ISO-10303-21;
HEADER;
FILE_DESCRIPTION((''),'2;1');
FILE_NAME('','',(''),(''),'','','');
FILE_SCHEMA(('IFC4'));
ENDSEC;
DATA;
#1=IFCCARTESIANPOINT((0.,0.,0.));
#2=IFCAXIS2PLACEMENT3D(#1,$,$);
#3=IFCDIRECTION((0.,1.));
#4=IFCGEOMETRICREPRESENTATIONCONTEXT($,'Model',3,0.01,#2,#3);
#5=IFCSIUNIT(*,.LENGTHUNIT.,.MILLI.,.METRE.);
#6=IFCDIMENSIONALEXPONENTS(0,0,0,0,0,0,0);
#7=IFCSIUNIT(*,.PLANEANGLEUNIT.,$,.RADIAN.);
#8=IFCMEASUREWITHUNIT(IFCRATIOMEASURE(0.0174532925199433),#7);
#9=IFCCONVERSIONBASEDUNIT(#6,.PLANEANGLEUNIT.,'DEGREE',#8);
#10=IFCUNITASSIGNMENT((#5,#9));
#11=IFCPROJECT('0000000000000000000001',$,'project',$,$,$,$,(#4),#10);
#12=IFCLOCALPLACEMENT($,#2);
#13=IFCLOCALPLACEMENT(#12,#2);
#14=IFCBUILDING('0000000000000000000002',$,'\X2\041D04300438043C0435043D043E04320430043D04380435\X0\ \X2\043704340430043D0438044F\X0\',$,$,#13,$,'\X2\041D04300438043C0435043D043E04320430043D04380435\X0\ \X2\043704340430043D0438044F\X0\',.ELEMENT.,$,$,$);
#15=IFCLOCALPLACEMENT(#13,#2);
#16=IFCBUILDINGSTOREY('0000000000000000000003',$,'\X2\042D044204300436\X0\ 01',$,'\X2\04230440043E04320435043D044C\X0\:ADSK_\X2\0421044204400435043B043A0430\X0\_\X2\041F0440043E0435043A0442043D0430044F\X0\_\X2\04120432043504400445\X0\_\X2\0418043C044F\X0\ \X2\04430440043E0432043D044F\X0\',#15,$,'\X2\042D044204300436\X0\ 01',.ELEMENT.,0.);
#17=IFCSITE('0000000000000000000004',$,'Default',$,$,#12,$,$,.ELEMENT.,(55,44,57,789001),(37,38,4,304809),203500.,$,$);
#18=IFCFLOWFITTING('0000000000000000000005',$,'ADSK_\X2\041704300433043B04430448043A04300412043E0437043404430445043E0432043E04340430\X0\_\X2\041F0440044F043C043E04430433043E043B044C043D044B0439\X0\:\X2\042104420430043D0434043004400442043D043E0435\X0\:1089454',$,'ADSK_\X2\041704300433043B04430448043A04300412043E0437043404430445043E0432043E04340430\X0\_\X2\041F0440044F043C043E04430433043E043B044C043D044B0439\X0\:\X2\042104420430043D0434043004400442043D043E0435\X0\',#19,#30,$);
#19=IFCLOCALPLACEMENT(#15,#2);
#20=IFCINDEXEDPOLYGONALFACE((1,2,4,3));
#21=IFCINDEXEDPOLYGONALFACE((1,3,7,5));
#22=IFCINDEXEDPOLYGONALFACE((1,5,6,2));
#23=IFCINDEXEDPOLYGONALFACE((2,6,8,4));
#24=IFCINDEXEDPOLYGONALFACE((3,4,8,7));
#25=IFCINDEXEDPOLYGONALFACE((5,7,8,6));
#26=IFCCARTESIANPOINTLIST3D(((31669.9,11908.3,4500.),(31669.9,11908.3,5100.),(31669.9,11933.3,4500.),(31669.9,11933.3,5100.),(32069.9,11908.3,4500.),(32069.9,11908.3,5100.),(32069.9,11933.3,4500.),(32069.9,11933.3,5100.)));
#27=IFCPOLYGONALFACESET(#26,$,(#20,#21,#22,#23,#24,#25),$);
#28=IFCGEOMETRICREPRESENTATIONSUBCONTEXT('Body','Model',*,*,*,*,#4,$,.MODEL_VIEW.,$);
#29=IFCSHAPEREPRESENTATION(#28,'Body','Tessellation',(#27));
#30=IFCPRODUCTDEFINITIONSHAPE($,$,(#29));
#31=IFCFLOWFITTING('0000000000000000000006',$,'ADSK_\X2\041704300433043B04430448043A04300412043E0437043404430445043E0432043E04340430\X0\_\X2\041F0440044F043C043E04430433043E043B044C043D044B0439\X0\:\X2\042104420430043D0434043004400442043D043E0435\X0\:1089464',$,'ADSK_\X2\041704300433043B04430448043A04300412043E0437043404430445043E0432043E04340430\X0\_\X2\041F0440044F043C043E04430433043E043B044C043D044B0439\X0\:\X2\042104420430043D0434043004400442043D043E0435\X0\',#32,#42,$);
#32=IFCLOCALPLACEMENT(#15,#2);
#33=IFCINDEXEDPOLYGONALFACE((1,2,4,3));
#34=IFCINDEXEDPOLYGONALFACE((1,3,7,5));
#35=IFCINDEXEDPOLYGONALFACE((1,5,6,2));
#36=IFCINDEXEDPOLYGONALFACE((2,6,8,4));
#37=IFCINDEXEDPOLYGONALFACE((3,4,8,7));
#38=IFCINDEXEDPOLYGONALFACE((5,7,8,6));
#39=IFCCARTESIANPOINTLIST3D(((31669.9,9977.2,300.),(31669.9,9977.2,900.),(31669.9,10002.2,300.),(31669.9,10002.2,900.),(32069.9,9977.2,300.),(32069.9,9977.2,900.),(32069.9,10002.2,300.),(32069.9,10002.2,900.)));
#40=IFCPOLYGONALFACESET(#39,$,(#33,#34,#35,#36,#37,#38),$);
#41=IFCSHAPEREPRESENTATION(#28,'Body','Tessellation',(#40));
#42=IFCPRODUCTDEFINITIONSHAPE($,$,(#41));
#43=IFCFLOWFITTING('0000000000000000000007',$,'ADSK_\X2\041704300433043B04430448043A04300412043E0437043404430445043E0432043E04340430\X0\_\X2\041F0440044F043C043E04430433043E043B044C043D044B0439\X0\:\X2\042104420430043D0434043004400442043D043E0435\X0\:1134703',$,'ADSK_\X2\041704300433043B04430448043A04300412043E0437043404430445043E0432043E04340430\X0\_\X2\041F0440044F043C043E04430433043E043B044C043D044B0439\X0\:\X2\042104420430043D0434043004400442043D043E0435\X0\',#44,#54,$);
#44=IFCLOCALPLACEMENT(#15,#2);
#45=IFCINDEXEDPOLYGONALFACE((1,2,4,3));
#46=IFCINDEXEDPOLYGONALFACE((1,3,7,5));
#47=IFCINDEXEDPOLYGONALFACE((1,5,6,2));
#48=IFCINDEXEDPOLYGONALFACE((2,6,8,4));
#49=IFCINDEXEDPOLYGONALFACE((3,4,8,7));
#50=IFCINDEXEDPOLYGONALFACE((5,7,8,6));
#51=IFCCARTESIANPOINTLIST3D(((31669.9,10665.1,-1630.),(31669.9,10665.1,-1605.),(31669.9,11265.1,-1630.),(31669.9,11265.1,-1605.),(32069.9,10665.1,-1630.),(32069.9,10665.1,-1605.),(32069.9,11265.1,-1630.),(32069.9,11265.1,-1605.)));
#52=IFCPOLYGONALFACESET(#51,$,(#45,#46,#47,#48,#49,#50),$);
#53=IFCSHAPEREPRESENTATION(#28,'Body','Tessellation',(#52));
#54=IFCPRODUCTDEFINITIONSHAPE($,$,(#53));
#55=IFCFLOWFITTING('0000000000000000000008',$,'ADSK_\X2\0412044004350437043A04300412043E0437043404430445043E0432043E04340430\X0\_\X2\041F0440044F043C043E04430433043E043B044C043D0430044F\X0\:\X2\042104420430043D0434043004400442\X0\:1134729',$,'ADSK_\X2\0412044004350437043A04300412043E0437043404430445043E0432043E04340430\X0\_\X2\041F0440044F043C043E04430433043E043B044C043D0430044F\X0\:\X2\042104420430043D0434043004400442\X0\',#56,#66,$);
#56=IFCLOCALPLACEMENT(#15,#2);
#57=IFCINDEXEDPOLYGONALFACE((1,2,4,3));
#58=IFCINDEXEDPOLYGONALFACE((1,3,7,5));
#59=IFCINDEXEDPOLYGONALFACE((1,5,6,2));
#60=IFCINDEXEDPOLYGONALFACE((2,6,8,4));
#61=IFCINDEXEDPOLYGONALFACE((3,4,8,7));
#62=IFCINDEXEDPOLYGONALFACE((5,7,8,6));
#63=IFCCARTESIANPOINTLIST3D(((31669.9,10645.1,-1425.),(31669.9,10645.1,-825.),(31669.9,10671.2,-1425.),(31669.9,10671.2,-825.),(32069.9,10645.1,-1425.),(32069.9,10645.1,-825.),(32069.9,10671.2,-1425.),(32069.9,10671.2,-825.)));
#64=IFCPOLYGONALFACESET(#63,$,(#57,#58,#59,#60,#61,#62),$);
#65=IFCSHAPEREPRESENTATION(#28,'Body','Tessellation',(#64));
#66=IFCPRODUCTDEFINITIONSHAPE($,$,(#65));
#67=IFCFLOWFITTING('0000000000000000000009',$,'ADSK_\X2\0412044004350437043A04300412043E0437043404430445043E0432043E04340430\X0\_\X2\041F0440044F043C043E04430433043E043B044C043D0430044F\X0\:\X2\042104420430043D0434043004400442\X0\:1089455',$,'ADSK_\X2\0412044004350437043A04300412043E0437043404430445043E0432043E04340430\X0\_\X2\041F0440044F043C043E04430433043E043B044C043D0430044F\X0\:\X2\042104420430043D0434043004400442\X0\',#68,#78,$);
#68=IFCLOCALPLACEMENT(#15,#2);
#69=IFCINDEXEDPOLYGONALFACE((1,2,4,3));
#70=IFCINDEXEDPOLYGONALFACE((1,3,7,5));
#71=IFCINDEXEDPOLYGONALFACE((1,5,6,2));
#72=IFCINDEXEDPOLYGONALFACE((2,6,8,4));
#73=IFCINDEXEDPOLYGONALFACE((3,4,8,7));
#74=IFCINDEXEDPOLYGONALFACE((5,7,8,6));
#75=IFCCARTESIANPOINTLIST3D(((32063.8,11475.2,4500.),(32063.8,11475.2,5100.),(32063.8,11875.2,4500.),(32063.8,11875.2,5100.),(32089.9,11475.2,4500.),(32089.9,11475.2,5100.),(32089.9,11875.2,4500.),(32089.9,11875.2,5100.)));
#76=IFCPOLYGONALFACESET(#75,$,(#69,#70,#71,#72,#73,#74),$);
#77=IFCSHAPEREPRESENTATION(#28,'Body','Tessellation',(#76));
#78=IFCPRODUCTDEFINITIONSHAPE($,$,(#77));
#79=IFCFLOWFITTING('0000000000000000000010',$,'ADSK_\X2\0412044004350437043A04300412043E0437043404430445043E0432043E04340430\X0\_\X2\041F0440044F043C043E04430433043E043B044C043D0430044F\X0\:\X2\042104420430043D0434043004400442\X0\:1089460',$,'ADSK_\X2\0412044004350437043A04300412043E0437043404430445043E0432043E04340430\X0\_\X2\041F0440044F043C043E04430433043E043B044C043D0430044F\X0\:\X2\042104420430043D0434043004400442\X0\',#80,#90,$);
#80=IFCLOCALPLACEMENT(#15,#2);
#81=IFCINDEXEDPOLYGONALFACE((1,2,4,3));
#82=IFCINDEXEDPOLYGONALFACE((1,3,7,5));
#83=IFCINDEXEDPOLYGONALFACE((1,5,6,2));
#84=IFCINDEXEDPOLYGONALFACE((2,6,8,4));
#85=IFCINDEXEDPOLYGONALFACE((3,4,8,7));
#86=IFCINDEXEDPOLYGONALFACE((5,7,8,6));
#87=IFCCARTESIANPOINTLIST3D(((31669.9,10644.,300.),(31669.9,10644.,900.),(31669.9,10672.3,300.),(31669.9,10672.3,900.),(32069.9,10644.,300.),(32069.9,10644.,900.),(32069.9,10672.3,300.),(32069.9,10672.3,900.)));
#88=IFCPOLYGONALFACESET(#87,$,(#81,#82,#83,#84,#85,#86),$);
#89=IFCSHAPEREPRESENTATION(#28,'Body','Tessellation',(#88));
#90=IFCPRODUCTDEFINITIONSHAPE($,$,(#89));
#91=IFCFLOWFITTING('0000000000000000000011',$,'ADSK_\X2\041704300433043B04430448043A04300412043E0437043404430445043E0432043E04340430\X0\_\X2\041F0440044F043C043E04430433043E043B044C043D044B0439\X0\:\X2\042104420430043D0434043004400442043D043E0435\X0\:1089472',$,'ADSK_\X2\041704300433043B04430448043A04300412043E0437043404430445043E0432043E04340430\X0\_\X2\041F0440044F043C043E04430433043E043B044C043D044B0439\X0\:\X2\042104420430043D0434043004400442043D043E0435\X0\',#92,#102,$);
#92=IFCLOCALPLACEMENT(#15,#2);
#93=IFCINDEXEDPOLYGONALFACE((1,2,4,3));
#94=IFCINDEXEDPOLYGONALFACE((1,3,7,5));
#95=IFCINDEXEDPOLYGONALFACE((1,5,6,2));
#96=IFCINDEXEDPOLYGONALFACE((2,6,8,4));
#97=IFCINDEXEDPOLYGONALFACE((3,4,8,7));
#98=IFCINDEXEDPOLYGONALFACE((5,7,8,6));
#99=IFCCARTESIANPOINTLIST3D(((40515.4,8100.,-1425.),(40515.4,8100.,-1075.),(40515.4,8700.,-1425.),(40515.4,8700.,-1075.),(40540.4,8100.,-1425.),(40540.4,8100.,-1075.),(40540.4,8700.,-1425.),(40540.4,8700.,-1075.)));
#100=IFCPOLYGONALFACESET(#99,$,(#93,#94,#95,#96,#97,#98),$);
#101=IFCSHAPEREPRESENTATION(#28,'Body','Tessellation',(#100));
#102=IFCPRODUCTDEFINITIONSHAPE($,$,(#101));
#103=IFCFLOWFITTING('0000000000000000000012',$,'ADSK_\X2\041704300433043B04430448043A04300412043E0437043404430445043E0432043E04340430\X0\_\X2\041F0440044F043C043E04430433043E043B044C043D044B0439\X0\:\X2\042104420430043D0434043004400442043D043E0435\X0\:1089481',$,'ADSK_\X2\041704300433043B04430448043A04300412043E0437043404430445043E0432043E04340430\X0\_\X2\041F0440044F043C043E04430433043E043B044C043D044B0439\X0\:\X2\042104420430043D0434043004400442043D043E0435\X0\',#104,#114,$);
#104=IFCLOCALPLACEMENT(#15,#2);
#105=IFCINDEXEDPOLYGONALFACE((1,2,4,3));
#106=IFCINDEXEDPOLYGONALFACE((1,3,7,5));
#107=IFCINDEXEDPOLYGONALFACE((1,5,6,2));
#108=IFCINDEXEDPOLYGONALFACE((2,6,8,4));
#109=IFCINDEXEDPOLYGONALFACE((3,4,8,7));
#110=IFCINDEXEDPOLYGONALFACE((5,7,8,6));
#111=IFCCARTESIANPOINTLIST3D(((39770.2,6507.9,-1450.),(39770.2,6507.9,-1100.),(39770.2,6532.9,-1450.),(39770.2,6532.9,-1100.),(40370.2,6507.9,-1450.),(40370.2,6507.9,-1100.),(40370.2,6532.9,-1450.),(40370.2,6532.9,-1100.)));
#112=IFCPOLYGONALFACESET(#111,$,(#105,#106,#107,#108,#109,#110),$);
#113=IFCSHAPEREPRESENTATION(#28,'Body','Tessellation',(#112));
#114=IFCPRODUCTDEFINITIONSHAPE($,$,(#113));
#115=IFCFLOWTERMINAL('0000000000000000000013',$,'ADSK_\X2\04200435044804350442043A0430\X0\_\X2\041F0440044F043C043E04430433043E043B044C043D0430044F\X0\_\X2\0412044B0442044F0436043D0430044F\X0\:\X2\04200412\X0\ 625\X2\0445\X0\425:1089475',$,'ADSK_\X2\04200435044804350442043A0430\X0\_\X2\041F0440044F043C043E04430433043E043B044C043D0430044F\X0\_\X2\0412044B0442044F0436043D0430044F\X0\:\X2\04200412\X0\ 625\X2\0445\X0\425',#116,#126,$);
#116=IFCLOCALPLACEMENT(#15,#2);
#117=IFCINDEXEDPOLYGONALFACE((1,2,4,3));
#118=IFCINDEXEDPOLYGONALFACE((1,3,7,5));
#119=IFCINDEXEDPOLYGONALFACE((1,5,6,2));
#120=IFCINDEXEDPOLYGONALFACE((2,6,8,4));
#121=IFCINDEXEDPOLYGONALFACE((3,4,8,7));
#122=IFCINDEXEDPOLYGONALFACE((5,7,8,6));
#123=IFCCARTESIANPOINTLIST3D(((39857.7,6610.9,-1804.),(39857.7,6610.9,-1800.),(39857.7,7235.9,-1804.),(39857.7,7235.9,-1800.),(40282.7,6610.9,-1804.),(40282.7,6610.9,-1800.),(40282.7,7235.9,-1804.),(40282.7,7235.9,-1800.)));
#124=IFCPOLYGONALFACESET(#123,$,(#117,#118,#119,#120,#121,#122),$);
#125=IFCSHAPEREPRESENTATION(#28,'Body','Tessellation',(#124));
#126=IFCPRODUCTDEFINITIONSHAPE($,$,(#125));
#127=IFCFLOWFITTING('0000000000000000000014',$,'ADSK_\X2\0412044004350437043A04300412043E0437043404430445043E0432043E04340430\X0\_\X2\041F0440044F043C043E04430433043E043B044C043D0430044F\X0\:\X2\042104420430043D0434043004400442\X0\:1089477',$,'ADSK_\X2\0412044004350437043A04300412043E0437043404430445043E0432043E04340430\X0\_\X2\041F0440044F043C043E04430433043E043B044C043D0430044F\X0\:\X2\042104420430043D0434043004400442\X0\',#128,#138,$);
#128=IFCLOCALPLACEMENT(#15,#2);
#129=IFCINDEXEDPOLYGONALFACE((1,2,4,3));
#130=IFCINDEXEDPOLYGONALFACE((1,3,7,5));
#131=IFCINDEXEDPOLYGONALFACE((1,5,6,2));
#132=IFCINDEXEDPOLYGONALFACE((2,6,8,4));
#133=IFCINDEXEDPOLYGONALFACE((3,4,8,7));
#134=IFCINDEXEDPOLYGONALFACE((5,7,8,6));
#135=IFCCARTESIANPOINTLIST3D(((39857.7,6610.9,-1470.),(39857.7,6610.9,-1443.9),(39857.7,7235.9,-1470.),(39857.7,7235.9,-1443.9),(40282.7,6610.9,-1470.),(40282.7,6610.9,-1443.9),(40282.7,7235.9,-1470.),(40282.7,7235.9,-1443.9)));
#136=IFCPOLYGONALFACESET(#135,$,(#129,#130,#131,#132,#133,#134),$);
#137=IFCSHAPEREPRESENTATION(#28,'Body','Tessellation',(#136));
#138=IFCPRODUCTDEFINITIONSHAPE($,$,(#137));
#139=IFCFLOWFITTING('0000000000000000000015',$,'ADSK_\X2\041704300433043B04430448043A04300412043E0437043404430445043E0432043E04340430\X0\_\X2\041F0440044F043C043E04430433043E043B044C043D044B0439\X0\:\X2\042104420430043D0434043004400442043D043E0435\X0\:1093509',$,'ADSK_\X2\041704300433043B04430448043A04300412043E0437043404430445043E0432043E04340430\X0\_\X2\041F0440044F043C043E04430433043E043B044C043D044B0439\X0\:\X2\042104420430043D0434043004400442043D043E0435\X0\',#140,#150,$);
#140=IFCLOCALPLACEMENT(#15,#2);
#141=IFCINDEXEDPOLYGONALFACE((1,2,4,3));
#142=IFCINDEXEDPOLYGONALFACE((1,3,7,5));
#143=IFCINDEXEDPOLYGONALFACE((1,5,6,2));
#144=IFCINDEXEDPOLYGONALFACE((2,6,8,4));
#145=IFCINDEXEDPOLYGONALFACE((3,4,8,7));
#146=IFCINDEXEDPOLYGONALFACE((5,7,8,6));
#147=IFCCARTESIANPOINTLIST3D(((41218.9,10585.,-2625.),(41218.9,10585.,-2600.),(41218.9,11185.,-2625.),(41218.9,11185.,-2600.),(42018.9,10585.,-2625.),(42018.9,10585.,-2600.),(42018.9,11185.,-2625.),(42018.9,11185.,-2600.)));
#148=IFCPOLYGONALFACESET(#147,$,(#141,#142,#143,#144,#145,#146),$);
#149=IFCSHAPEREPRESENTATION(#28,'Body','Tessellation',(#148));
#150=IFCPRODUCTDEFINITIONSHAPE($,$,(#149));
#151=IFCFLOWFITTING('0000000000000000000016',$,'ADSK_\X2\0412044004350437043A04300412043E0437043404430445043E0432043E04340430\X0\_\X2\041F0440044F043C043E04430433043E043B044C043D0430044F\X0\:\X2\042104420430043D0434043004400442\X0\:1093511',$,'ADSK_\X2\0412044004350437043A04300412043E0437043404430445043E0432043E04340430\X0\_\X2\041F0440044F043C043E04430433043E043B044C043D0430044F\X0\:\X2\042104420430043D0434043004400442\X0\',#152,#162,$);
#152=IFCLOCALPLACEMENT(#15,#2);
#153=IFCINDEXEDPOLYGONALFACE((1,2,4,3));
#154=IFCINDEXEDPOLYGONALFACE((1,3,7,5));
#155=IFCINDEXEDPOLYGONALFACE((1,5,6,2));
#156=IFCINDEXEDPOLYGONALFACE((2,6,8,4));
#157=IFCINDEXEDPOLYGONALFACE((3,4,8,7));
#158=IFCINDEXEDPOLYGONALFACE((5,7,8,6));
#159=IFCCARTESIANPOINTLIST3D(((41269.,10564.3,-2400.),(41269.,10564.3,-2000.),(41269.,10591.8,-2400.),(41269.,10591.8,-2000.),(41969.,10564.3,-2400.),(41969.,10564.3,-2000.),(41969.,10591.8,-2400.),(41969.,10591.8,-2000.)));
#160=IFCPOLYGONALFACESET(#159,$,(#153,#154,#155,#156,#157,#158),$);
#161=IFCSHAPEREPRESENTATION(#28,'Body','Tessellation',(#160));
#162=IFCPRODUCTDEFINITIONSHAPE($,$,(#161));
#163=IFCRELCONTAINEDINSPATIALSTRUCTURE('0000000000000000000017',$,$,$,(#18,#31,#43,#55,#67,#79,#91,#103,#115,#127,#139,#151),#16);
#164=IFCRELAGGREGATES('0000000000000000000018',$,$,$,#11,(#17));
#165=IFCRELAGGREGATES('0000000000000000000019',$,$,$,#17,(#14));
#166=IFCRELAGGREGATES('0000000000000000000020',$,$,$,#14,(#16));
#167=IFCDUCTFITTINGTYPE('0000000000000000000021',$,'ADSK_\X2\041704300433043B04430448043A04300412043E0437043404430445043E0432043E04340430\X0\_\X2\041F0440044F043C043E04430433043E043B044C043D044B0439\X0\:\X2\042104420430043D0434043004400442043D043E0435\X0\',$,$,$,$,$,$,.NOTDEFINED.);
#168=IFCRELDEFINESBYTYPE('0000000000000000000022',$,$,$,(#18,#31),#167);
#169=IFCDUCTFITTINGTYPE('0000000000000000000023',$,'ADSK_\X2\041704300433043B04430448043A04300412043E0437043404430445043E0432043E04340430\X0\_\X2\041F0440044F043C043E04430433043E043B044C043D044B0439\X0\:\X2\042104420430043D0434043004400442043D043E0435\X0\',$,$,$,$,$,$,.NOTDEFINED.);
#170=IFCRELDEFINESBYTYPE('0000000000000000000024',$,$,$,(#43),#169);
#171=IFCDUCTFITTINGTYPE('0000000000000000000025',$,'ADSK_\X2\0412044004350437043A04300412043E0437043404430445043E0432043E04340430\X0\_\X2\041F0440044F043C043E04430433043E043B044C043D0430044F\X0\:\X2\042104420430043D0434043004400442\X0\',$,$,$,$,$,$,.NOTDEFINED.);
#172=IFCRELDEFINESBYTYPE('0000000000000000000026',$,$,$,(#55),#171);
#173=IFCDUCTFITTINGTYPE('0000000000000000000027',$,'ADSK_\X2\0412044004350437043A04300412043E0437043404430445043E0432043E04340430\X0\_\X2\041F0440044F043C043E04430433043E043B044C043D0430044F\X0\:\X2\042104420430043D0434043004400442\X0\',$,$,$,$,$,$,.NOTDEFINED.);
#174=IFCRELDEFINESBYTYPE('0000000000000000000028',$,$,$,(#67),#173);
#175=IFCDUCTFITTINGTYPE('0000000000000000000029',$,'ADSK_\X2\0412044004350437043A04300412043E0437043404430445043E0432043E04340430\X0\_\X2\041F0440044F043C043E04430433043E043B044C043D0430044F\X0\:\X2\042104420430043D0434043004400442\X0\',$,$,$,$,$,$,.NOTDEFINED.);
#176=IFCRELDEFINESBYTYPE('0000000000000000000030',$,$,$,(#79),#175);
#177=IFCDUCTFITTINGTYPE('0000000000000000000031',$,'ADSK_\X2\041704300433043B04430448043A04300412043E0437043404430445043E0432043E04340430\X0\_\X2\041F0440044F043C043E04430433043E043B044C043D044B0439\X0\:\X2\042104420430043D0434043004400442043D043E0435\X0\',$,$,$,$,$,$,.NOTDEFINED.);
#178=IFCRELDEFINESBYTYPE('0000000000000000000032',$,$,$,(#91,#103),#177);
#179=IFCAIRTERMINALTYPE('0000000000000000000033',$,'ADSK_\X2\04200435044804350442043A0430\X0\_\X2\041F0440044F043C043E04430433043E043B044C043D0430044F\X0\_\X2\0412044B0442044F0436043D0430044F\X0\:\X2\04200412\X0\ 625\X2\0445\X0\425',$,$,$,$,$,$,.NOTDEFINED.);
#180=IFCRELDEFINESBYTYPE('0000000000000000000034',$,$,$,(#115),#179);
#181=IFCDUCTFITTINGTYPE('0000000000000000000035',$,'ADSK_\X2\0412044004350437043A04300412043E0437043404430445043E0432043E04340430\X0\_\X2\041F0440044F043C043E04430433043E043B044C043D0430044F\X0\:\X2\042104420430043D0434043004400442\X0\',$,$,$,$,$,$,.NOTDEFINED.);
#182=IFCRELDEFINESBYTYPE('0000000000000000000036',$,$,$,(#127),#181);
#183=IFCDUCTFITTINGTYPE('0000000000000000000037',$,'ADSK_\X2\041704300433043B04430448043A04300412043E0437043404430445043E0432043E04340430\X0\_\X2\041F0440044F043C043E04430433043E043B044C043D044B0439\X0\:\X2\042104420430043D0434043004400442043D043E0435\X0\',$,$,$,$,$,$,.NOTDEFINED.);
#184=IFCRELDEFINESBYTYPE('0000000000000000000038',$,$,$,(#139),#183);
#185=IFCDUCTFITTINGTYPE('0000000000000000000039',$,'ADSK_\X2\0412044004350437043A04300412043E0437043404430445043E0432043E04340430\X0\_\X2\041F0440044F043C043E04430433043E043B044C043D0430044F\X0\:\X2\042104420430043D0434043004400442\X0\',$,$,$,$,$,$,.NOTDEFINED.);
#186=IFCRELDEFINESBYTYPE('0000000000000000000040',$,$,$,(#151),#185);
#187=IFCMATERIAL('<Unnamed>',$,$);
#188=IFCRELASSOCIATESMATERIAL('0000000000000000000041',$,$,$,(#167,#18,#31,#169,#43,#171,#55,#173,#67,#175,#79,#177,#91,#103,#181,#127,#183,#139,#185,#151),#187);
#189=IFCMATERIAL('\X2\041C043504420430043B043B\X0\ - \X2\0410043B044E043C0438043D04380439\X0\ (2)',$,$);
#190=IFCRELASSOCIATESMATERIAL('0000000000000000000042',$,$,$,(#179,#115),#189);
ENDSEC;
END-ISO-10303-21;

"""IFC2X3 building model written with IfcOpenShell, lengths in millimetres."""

from ifc_helpers import new_model, entity, si_unit, converted_unit, direction, frame, frame_2d, origin, origin_2d_with_axis, place, context, subcontext, project, spatial, rectangle, extrude, source, transform, mapped, material, type_object, type_shapes, element, save


model = new_model("IFC2X3")

# Units and contexts
model_context = context("Model", 3, precision=0.01, world=origin(), true_north=direction((0.0, 1.0)))
body_context = subcontext(model_context, "Body", "Model", "MODEL_VIEW")
ifc_project = project(units=[si_unit("LENGTHUNIT", "METRE", prefix="MILLI"), converted_unit("PLANEANGLEUNIT", "DEGREE", entity("IfcRatioMeasure", 0.0174532925199433), si_unit("PLANEANGLEUNIT", "RADIAN"), dimensions=[0, 0, 0, 0, 0, 0, 0])], contexts=[model_context])

# Site, building, storey
site_placement = place(None, frame((0.0, 0.0, 0.0)))
site = spatial("IfcSite", under=ifc_project, at=site_placement, Name="Default", CompositionType="ELEMENT", RefLatitude=(55, 44, 57, 789001), RefLongitude=(37, 38, 4, 304809), RefElevation=203500.0)
building_placement = place(site_placement, origin())
building = spatial("IfcBuilding", under=site, at=building_placement, Name="Наименование здания", LongName="Наименование здания", CompositionType="ELEMENT")
storey_placement = place(building_placement, origin())
storey = spatial("IfcBuildingStorey", under=building, at=storey_placement, Name="Этаж 01", ObjectType="Уровень:ADSK_Стрелка_Проектная_Вверх_Имя уровня", LongName="Этаж 01", CompositionType="ELEMENT", Elevation=0.0)

# Flow fittings
ifc_material_1 = material(Name="<Unnamed>")
duct_fitting_type_1 = type_object("IfcDuctFittingType", Name="ADSK_ЗаглушкаВоздуховода_Прямоугольный:Стандартное", PredefinedType="NOTDEFINED", material=ifc_material_1)
shared_shape_1 = source(origin(), body_context, "Body", "SweptSolid", [
    extrude(rectangle(XDim=25.0, YDim=400.0, at=frame_2d((0.0, 0.0), x_axis=(1.0, 0.0))), frame((12.5, 0.0, -300.0)), (0.0, 0.0, 1.0), 600.0),
])
type_shapes(duct_fitting_type_1, [shared_shape_1])
for number, where, z_axis, x_axis, name in (
    (1, (31869.9, 11908.3, 4800.0), (0.0, 0.0, 1.0), (0.0, 1.0, 0.0), "ADSK_ЗаглушкаВоздуховода_Прямоугольный:Стандартное:1089454"),
    (2, (31869.9, 10002.2, 600.0), (0.0, 0.0, 1.0), (0.0, -1.0, 0.0), "ADSK_ЗаглушкаВоздуховода_Прямоугольный:Стандартное:1089464"),
):
    element("IfcFlowFitting", number, at=place(storey_placement, frame(where, z_axis=z_axis, x_axis=x_axis)), inside=storey, type_object=duct_fitting_type_1, material=ifc_material_1, Name=name, ObjectType="ADSK_ЗаглушкаВоздуховода_Прямоугольный:Стандартное", context=body_context, shape_type="MappedRepresentation", body=[
        mapped(shared_shape_1, transform((0.0, 0.0, 0.0), scale=1.0)),
    ])
duct_fitting_type_2 = type_object("IfcDuctFittingType", Name="ADSK_ЗаглушкаВоздуховода_Прямоугольный:Стандартное", PredefinedType="NOTDEFINED", material=ifc_material_1)
shared_shape_2 = source(origin(), body_context, "Body", "SweptSolid", [
    extrude(rectangle(XDim=25.0, YDim=600.0, at=frame_2d((0.0, 0.0), x_axis=(1.0, 0.0))), frame((12.5, 0.0, -200.0)), (0.0, 0.0, 1.0), 400.0),
])
type_shapes(duct_fitting_type_2, [shared_shape_2])
flow_fitting_1_placement = place(storey_placement, frame((31869.9, 10965.1, -1605.0), z_axis=(1.0, 0.0, 0.0), x_axis=(0.0, 0.0, -1.0)))
element("IfcFlowFitting", 3, at=flow_fitting_1_placement, inside=storey, type_object=duct_fitting_type_2, material=ifc_material_1, Name="ADSK_ЗаглушкаВоздуховода_Прямоугольный:Стандартное:1134703", ObjectType="ADSK_ЗаглушкаВоздуховода_Прямоугольный:Стандартное", context=body_context, shape_type="MappedRepresentation", body=[
    mapped(shared_shape_2, transform((0.0, 0.0, 0.0), scale=1.0)),
])
duct_fitting_type_3 = type_object("IfcDuctFittingType", Name="ADSK_ВрезкаВоздуховода_Прямоугольная:Стандарт", PredefinedType="NOTDEFINED", material=ifc_material_1)
shared_shape_3 = source(origin(), body_context, "Body", "SweptSolid", [
    extrude(rectangle(XDim=600.0, YDim=26.1, at=origin_2d_with_axis()), frame((7.0, 0.0, -200.0), z_axis=(0.0, 0.0, 1.0), x_axis=(0.0, -1.0, 0.0)), (0.0, 0.0, 1.0), 400.0),
])
type_shapes(duct_fitting_type_3, [shared_shape_3])
flow_fitting_2_placement = place(storey_placement, frame((31869.9, 10665.1, -1125.0), z_axis=(-1.0, 0.0, 0.0), x_axis=(0.0, -1.0, 0.0)))
element("IfcFlowFitting", 4, at=flow_fitting_2_placement, inside=storey, type_object=duct_fitting_type_3, material=ifc_material_1, Name="ADSK_ВрезкаВоздуховода_Прямоугольная:Стандарт:1134729", ObjectType="ADSK_ВрезкаВоздуховода_Прямоугольная:Стандарт", context=body_context, shape_type="MappedRepresentation", body=[
    mapped(shared_shape_3, transform((0.0, 0.0, 0.0), scale=1.0)),
])
duct_fitting_type_4 = type_object("IfcDuctFittingType", Name="ADSK_ВрезкаВоздуховода_Прямоугольная:Стандарт", PredefinedType="NOTDEFINED", material=ifc_material_1)
shared_shape_4 = source(origin(), body_context, "Body", "SweptSolid", [
    extrude(rectangle(XDim=26.1, YDim=400.0, at=frame_2d((0.0, 0.0), x_axis=(1.0, 0.0))), frame((7.0, 0.0, -300.0)), (0.0, 0.0, 1.0), 600.0),
])
type_shapes(duct_fitting_type_4, [shared_shape_4])
flow_fitting_3_placement = place(storey_placement, frame((32069.9, 11675.2, 4800.0), z_axis=(0.0, 0.0, -1.0), x_axis=(1.0, 0.0, 0.0)))
element("IfcFlowFitting", 5, at=flow_fitting_3_placement, inside=storey, type_object=duct_fitting_type_4, material=ifc_material_1, Name="ADSK_ВрезкаВоздуховода_Прямоугольная:Стандарт:1089455", ObjectType="ADSK_ВрезкаВоздуховода_Прямоугольная:Стандарт", context=body_context, shape_type="MappedRepresentation", body=[
    mapped(shared_shape_4, transform((0.0, 0.0, 0.0), scale=1.0)),
])
duct_fitting_type_5 = type_object("IfcDuctFittingType", Name="ADSK_ВрезкаВоздуховода_Прямоугольная:Стандарт", PredefinedType="NOTDEFINED", material=ifc_material_1)
shared_shape_5 = source(origin(), body_context, "Body", "SweptSolid", [
    extrude(rectangle(XDim=28.2, YDim=600.0, at=frame_2d((0.0, 0.0), x_axis=(1.0, 0.0))), frame((7.0, 0.0, -200.0)), (0.0, 0.0, 1.0), 400.0),
])
type_shapes(duct_fitting_type_5, [shared_shape_5])
flow_fitting_4_placement = place(storey_placement, frame((31869.9, 10665.1, 600.0), z_axis=(-1.0, 0.0, 0.0), x_axis=(0.0, -1.0, 0.0)))
element("IfcFlowFitting", 6, at=flow_fitting_4_placement, inside=storey, type_object=duct_fitting_type_5, material=ifc_material_1, Name="ADSK_ВрезкаВоздуховода_Прямоугольная:Стандарт:1089460", ObjectType="ADSK_ВрезкаВоздуховода_Прямоугольная:Стандарт", context=body_context, shape_type="MappedRepresentation", body=[
    mapped(shared_shape_5, transform((0.0, 0.0, 0.0), scale=1.0)),
])
duct_fitting_type_6 = type_object("IfcDuctFittingType", Name="ADSK_ЗаглушкаВоздуховода_Прямоугольный:Стандартное", PredefinedType="NOTDEFINED", material=ifc_material_1)
shared_shape_6 = source(origin(), body_context, "Body", "SweptSolid", [
    extrude(rectangle(XDim=25.0, YDim=600.0, at=frame_2d((0.0, 0.0), x_axis=(1.0, 0.0))), frame((12.5, 0.0, -175.0)), (0.0, 0.0, 1.0), 350.0),
])
type_shapes(duct_fitting_type_6, [shared_shape_6])
flow_fitting_5_placement = place(storey_placement, frame((40515.4, 8400.0, -1250.0)))
element("IfcFlowFitting", 7, at=flow_fitting_5_placement, inside=storey, type_object=duct_fitting_type_6, material=ifc_material_1, Name="ADSK_ЗаглушкаВоздуховода_Прямоугольный:Стандартное:1089472", ObjectType="ADSK_ЗаглушкаВоздуховода_Прямоугольный:Стандартное", context=body_context, shape_type="MappedRepresentation", body=[
    mapped(shared_shape_6, transform((0.0, 0.0, 0.0), scale=1.0)),
])
flow_fitting_6_placement = place(storey_placement, frame((40070.2, 6532.9, -1275.0), z_axis=(0.0, 0.0, 1.0), x_axis=(0.0, -1.0, 0.0)))
element("IfcFlowFitting", 8, at=flow_fitting_6_placement, inside=storey, type_object=duct_fitting_type_6, material=ifc_material_1, Name="ADSK_ЗаглушкаВоздуховода_Прямоугольный:Стандартное:1089481", ObjectType="ADSK_ЗаглушкаВоздуховода_Прямоугольный:Стандартное", context=body_context, shape_type="MappedRepresentation", body=[
    mapped(shared_shape_6, transform((0.0, 0.0, 0.0), scale=1.0)),
])

# Flow terminal
ifc_material_2 = material(Name="Металл - Алюминий (2)")
air_terminal_type = type_object("IfcAirTerminalType", Name="ADSK_Решетка_Прямоугольная_Вытяжная:РВ 625х425", PredefinedType="NOTDEFINED", material=ifc_material_2)
shared_shape_7 = source(origin(), body_context, "Body", "SweptSolid", [
    extrude(rectangle(XDim=4.0, YDim=625.0, at=origin_2d_with_axis()), frame((0.0, -2.0, -212.5), z_axis=(0.0, 0.0, 1.0), x_axis=(0.0, 1.0, 0.0)), (0.0, 0.0, 1.0), 425.0),
])
type_shapes(air_terminal_type, [shared_shape_7])
flow_terminal_placement = place(storey_placement, frame((40070.2, 6923.4, -1800.0), z_axis=(1.0, 0.0, 0.0), x_axis=(0.0, 1.0, 0.0)))
element("IfcFlowTerminal", 9, at=flow_terminal_placement, inside=storey, type_object=air_terminal_type, material=ifc_material_2, Name="ADSK_Решетка_Прямоугольная_Вытяжная:РВ 625х425:1089475", ObjectType="ADSK_Решетка_Прямоугольная_Вытяжная:РВ 625х425", context=body_context, shape_type="MappedRepresentation", body=[
    mapped(shared_shape_7, transform((0.0, 0.0, 0.0), scale=1.0)),
])

# Flow fittings
duct_fitting_type_7 = type_object("IfcDuctFittingType", Name="ADSK_ВрезкаВоздуховода_Прямоугольная:Стандарт", PredefinedType="NOTDEFINED", material=ifc_material_1)
shared_shape_8 = source(origin(), body_context, "Body", "SweptSolid", [
    extrude(rectangle(XDim=425.0, YDim=26.1, at=origin_2d_with_axis()), frame((7.0, 0.0, -312.5), z_axis=(0.0, 0.0, 1.0), x_axis=(0.0, -1.0, 0.0)), (0.0, 0.0, 1.0), 625.0),
])
type_shapes(duct_fitting_type_7, [shared_shape_8])
flow_fitting_7_placement = place(storey_placement, frame((40070.2, 6923.4, -1450.0), z_axis=(0.0, -1.0, 0.0), x_axis=(0.0, 0.0, -1.0)))
element("IfcFlowFitting", 10, at=flow_fitting_7_placement, inside=storey, type_object=duct_fitting_type_7, material=ifc_material_1, Name="ADSK_ВрезкаВоздуховода_Прямоугольная:Стандарт:1089477", ObjectType="ADSK_ВрезкаВоздуховода_Прямоугольная:Стандарт", context=body_context, shape_type="MappedRepresentation", body=[
    mapped(shared_shape_8, transform((0.0, 0.0, 0.0), scale=1.0)),
])
duct_fitting_type_8 = type_object("IfcDuctFittingType", Name="ADSK_ЗаглушкаВоздуховода_Прямоугольный:Стандартное", PredefinedType="NOTDEFINED", material=ifc_material_1)
shared_shape_9 = source(origin(), body_context, "Body", "SweptSolid", [
    extrude(rectangle(XDim=25.0, YDim=600.0, at=frame_2d((0.0, 0.0), x_axis=(1.0, 0.0))), frame((12.5, 0.0, -400.0)), (0.0, 0.0, 1.0), 800.0),
])
type_shapes(duct_fitting_type_8, [shared_shape_9])
flow_fitting_8_placement = place(storey_placement, frame((41618.9, 10885.0, -2600.0), z_axis=(1.0, 0.0, 0.0), x_axis=(0.0, 0.0, -1.0)))
element("IfcFlowFitting", 11, at=flow_fitting_8_placement, inside=storey, type_object=duct_fitting_type_8, material=ifc_material_1, Name="ADSK_ЗаглушкаВоздуховода_Прямоугольный:Стандартное:1093509", ObjectType="ADSK_ЗаглушкаВоздуховода_Прямоугольный:Стандартное", context=body_context, shape_type="MappedRepresentation", body=[
    mapped(shared_shape_9, transform((0.0, 0.0, 0.0), scale=1.0)),
])
duct_fitting_type_9 = type_object("IfcDuctFittingType", Name="ADSK_ВрезкаВоздуховода_Прямоугольная:Стандарт", PredefinedType="NOTDEFINED", material=ifc_material_1)
shared_shape_10 = source(origin(), body_context, "Body", "SweptSolid", [
    extrude(rectangle(XDim=27.5, YDim=400.0, at=frame_2d((0.0, 0.0), x_axis=(1.0, 0.0))), frame((7.0, 0.0, -350.0)), (0.0, 0.0, 1.0), 700.0),
])
type_shapes(duct_fitting_type_9, [shared_shape_10])
flow_fitting_9_placement = place(storey_placement, frame((41619.0, 10585.0, -2200.0), z_axis=(-1.0, 0.0, 0.0), x_axis=(0.0, -1.0, 0.0)))
element("IfcFlowFitting", 12, at=flow_fitting_9_placement, inside=storey, type_object=duct_fitting_type_9, material=ifc_material_1, Name="ADSK_ВрезкаВоздуховода_Прямоугольная:Стандарт:1093511", ObjectType="ADSK_ВрезкаВоздуховода_Прямоугольная:Стандарт", context=body_context, shape_type="MappedRepresentation", body=[
    mapped(shared_shape_10, transform((0.0, 0.0, 0.0), scale=1.0)),
])

save(model, "model.ifc")
